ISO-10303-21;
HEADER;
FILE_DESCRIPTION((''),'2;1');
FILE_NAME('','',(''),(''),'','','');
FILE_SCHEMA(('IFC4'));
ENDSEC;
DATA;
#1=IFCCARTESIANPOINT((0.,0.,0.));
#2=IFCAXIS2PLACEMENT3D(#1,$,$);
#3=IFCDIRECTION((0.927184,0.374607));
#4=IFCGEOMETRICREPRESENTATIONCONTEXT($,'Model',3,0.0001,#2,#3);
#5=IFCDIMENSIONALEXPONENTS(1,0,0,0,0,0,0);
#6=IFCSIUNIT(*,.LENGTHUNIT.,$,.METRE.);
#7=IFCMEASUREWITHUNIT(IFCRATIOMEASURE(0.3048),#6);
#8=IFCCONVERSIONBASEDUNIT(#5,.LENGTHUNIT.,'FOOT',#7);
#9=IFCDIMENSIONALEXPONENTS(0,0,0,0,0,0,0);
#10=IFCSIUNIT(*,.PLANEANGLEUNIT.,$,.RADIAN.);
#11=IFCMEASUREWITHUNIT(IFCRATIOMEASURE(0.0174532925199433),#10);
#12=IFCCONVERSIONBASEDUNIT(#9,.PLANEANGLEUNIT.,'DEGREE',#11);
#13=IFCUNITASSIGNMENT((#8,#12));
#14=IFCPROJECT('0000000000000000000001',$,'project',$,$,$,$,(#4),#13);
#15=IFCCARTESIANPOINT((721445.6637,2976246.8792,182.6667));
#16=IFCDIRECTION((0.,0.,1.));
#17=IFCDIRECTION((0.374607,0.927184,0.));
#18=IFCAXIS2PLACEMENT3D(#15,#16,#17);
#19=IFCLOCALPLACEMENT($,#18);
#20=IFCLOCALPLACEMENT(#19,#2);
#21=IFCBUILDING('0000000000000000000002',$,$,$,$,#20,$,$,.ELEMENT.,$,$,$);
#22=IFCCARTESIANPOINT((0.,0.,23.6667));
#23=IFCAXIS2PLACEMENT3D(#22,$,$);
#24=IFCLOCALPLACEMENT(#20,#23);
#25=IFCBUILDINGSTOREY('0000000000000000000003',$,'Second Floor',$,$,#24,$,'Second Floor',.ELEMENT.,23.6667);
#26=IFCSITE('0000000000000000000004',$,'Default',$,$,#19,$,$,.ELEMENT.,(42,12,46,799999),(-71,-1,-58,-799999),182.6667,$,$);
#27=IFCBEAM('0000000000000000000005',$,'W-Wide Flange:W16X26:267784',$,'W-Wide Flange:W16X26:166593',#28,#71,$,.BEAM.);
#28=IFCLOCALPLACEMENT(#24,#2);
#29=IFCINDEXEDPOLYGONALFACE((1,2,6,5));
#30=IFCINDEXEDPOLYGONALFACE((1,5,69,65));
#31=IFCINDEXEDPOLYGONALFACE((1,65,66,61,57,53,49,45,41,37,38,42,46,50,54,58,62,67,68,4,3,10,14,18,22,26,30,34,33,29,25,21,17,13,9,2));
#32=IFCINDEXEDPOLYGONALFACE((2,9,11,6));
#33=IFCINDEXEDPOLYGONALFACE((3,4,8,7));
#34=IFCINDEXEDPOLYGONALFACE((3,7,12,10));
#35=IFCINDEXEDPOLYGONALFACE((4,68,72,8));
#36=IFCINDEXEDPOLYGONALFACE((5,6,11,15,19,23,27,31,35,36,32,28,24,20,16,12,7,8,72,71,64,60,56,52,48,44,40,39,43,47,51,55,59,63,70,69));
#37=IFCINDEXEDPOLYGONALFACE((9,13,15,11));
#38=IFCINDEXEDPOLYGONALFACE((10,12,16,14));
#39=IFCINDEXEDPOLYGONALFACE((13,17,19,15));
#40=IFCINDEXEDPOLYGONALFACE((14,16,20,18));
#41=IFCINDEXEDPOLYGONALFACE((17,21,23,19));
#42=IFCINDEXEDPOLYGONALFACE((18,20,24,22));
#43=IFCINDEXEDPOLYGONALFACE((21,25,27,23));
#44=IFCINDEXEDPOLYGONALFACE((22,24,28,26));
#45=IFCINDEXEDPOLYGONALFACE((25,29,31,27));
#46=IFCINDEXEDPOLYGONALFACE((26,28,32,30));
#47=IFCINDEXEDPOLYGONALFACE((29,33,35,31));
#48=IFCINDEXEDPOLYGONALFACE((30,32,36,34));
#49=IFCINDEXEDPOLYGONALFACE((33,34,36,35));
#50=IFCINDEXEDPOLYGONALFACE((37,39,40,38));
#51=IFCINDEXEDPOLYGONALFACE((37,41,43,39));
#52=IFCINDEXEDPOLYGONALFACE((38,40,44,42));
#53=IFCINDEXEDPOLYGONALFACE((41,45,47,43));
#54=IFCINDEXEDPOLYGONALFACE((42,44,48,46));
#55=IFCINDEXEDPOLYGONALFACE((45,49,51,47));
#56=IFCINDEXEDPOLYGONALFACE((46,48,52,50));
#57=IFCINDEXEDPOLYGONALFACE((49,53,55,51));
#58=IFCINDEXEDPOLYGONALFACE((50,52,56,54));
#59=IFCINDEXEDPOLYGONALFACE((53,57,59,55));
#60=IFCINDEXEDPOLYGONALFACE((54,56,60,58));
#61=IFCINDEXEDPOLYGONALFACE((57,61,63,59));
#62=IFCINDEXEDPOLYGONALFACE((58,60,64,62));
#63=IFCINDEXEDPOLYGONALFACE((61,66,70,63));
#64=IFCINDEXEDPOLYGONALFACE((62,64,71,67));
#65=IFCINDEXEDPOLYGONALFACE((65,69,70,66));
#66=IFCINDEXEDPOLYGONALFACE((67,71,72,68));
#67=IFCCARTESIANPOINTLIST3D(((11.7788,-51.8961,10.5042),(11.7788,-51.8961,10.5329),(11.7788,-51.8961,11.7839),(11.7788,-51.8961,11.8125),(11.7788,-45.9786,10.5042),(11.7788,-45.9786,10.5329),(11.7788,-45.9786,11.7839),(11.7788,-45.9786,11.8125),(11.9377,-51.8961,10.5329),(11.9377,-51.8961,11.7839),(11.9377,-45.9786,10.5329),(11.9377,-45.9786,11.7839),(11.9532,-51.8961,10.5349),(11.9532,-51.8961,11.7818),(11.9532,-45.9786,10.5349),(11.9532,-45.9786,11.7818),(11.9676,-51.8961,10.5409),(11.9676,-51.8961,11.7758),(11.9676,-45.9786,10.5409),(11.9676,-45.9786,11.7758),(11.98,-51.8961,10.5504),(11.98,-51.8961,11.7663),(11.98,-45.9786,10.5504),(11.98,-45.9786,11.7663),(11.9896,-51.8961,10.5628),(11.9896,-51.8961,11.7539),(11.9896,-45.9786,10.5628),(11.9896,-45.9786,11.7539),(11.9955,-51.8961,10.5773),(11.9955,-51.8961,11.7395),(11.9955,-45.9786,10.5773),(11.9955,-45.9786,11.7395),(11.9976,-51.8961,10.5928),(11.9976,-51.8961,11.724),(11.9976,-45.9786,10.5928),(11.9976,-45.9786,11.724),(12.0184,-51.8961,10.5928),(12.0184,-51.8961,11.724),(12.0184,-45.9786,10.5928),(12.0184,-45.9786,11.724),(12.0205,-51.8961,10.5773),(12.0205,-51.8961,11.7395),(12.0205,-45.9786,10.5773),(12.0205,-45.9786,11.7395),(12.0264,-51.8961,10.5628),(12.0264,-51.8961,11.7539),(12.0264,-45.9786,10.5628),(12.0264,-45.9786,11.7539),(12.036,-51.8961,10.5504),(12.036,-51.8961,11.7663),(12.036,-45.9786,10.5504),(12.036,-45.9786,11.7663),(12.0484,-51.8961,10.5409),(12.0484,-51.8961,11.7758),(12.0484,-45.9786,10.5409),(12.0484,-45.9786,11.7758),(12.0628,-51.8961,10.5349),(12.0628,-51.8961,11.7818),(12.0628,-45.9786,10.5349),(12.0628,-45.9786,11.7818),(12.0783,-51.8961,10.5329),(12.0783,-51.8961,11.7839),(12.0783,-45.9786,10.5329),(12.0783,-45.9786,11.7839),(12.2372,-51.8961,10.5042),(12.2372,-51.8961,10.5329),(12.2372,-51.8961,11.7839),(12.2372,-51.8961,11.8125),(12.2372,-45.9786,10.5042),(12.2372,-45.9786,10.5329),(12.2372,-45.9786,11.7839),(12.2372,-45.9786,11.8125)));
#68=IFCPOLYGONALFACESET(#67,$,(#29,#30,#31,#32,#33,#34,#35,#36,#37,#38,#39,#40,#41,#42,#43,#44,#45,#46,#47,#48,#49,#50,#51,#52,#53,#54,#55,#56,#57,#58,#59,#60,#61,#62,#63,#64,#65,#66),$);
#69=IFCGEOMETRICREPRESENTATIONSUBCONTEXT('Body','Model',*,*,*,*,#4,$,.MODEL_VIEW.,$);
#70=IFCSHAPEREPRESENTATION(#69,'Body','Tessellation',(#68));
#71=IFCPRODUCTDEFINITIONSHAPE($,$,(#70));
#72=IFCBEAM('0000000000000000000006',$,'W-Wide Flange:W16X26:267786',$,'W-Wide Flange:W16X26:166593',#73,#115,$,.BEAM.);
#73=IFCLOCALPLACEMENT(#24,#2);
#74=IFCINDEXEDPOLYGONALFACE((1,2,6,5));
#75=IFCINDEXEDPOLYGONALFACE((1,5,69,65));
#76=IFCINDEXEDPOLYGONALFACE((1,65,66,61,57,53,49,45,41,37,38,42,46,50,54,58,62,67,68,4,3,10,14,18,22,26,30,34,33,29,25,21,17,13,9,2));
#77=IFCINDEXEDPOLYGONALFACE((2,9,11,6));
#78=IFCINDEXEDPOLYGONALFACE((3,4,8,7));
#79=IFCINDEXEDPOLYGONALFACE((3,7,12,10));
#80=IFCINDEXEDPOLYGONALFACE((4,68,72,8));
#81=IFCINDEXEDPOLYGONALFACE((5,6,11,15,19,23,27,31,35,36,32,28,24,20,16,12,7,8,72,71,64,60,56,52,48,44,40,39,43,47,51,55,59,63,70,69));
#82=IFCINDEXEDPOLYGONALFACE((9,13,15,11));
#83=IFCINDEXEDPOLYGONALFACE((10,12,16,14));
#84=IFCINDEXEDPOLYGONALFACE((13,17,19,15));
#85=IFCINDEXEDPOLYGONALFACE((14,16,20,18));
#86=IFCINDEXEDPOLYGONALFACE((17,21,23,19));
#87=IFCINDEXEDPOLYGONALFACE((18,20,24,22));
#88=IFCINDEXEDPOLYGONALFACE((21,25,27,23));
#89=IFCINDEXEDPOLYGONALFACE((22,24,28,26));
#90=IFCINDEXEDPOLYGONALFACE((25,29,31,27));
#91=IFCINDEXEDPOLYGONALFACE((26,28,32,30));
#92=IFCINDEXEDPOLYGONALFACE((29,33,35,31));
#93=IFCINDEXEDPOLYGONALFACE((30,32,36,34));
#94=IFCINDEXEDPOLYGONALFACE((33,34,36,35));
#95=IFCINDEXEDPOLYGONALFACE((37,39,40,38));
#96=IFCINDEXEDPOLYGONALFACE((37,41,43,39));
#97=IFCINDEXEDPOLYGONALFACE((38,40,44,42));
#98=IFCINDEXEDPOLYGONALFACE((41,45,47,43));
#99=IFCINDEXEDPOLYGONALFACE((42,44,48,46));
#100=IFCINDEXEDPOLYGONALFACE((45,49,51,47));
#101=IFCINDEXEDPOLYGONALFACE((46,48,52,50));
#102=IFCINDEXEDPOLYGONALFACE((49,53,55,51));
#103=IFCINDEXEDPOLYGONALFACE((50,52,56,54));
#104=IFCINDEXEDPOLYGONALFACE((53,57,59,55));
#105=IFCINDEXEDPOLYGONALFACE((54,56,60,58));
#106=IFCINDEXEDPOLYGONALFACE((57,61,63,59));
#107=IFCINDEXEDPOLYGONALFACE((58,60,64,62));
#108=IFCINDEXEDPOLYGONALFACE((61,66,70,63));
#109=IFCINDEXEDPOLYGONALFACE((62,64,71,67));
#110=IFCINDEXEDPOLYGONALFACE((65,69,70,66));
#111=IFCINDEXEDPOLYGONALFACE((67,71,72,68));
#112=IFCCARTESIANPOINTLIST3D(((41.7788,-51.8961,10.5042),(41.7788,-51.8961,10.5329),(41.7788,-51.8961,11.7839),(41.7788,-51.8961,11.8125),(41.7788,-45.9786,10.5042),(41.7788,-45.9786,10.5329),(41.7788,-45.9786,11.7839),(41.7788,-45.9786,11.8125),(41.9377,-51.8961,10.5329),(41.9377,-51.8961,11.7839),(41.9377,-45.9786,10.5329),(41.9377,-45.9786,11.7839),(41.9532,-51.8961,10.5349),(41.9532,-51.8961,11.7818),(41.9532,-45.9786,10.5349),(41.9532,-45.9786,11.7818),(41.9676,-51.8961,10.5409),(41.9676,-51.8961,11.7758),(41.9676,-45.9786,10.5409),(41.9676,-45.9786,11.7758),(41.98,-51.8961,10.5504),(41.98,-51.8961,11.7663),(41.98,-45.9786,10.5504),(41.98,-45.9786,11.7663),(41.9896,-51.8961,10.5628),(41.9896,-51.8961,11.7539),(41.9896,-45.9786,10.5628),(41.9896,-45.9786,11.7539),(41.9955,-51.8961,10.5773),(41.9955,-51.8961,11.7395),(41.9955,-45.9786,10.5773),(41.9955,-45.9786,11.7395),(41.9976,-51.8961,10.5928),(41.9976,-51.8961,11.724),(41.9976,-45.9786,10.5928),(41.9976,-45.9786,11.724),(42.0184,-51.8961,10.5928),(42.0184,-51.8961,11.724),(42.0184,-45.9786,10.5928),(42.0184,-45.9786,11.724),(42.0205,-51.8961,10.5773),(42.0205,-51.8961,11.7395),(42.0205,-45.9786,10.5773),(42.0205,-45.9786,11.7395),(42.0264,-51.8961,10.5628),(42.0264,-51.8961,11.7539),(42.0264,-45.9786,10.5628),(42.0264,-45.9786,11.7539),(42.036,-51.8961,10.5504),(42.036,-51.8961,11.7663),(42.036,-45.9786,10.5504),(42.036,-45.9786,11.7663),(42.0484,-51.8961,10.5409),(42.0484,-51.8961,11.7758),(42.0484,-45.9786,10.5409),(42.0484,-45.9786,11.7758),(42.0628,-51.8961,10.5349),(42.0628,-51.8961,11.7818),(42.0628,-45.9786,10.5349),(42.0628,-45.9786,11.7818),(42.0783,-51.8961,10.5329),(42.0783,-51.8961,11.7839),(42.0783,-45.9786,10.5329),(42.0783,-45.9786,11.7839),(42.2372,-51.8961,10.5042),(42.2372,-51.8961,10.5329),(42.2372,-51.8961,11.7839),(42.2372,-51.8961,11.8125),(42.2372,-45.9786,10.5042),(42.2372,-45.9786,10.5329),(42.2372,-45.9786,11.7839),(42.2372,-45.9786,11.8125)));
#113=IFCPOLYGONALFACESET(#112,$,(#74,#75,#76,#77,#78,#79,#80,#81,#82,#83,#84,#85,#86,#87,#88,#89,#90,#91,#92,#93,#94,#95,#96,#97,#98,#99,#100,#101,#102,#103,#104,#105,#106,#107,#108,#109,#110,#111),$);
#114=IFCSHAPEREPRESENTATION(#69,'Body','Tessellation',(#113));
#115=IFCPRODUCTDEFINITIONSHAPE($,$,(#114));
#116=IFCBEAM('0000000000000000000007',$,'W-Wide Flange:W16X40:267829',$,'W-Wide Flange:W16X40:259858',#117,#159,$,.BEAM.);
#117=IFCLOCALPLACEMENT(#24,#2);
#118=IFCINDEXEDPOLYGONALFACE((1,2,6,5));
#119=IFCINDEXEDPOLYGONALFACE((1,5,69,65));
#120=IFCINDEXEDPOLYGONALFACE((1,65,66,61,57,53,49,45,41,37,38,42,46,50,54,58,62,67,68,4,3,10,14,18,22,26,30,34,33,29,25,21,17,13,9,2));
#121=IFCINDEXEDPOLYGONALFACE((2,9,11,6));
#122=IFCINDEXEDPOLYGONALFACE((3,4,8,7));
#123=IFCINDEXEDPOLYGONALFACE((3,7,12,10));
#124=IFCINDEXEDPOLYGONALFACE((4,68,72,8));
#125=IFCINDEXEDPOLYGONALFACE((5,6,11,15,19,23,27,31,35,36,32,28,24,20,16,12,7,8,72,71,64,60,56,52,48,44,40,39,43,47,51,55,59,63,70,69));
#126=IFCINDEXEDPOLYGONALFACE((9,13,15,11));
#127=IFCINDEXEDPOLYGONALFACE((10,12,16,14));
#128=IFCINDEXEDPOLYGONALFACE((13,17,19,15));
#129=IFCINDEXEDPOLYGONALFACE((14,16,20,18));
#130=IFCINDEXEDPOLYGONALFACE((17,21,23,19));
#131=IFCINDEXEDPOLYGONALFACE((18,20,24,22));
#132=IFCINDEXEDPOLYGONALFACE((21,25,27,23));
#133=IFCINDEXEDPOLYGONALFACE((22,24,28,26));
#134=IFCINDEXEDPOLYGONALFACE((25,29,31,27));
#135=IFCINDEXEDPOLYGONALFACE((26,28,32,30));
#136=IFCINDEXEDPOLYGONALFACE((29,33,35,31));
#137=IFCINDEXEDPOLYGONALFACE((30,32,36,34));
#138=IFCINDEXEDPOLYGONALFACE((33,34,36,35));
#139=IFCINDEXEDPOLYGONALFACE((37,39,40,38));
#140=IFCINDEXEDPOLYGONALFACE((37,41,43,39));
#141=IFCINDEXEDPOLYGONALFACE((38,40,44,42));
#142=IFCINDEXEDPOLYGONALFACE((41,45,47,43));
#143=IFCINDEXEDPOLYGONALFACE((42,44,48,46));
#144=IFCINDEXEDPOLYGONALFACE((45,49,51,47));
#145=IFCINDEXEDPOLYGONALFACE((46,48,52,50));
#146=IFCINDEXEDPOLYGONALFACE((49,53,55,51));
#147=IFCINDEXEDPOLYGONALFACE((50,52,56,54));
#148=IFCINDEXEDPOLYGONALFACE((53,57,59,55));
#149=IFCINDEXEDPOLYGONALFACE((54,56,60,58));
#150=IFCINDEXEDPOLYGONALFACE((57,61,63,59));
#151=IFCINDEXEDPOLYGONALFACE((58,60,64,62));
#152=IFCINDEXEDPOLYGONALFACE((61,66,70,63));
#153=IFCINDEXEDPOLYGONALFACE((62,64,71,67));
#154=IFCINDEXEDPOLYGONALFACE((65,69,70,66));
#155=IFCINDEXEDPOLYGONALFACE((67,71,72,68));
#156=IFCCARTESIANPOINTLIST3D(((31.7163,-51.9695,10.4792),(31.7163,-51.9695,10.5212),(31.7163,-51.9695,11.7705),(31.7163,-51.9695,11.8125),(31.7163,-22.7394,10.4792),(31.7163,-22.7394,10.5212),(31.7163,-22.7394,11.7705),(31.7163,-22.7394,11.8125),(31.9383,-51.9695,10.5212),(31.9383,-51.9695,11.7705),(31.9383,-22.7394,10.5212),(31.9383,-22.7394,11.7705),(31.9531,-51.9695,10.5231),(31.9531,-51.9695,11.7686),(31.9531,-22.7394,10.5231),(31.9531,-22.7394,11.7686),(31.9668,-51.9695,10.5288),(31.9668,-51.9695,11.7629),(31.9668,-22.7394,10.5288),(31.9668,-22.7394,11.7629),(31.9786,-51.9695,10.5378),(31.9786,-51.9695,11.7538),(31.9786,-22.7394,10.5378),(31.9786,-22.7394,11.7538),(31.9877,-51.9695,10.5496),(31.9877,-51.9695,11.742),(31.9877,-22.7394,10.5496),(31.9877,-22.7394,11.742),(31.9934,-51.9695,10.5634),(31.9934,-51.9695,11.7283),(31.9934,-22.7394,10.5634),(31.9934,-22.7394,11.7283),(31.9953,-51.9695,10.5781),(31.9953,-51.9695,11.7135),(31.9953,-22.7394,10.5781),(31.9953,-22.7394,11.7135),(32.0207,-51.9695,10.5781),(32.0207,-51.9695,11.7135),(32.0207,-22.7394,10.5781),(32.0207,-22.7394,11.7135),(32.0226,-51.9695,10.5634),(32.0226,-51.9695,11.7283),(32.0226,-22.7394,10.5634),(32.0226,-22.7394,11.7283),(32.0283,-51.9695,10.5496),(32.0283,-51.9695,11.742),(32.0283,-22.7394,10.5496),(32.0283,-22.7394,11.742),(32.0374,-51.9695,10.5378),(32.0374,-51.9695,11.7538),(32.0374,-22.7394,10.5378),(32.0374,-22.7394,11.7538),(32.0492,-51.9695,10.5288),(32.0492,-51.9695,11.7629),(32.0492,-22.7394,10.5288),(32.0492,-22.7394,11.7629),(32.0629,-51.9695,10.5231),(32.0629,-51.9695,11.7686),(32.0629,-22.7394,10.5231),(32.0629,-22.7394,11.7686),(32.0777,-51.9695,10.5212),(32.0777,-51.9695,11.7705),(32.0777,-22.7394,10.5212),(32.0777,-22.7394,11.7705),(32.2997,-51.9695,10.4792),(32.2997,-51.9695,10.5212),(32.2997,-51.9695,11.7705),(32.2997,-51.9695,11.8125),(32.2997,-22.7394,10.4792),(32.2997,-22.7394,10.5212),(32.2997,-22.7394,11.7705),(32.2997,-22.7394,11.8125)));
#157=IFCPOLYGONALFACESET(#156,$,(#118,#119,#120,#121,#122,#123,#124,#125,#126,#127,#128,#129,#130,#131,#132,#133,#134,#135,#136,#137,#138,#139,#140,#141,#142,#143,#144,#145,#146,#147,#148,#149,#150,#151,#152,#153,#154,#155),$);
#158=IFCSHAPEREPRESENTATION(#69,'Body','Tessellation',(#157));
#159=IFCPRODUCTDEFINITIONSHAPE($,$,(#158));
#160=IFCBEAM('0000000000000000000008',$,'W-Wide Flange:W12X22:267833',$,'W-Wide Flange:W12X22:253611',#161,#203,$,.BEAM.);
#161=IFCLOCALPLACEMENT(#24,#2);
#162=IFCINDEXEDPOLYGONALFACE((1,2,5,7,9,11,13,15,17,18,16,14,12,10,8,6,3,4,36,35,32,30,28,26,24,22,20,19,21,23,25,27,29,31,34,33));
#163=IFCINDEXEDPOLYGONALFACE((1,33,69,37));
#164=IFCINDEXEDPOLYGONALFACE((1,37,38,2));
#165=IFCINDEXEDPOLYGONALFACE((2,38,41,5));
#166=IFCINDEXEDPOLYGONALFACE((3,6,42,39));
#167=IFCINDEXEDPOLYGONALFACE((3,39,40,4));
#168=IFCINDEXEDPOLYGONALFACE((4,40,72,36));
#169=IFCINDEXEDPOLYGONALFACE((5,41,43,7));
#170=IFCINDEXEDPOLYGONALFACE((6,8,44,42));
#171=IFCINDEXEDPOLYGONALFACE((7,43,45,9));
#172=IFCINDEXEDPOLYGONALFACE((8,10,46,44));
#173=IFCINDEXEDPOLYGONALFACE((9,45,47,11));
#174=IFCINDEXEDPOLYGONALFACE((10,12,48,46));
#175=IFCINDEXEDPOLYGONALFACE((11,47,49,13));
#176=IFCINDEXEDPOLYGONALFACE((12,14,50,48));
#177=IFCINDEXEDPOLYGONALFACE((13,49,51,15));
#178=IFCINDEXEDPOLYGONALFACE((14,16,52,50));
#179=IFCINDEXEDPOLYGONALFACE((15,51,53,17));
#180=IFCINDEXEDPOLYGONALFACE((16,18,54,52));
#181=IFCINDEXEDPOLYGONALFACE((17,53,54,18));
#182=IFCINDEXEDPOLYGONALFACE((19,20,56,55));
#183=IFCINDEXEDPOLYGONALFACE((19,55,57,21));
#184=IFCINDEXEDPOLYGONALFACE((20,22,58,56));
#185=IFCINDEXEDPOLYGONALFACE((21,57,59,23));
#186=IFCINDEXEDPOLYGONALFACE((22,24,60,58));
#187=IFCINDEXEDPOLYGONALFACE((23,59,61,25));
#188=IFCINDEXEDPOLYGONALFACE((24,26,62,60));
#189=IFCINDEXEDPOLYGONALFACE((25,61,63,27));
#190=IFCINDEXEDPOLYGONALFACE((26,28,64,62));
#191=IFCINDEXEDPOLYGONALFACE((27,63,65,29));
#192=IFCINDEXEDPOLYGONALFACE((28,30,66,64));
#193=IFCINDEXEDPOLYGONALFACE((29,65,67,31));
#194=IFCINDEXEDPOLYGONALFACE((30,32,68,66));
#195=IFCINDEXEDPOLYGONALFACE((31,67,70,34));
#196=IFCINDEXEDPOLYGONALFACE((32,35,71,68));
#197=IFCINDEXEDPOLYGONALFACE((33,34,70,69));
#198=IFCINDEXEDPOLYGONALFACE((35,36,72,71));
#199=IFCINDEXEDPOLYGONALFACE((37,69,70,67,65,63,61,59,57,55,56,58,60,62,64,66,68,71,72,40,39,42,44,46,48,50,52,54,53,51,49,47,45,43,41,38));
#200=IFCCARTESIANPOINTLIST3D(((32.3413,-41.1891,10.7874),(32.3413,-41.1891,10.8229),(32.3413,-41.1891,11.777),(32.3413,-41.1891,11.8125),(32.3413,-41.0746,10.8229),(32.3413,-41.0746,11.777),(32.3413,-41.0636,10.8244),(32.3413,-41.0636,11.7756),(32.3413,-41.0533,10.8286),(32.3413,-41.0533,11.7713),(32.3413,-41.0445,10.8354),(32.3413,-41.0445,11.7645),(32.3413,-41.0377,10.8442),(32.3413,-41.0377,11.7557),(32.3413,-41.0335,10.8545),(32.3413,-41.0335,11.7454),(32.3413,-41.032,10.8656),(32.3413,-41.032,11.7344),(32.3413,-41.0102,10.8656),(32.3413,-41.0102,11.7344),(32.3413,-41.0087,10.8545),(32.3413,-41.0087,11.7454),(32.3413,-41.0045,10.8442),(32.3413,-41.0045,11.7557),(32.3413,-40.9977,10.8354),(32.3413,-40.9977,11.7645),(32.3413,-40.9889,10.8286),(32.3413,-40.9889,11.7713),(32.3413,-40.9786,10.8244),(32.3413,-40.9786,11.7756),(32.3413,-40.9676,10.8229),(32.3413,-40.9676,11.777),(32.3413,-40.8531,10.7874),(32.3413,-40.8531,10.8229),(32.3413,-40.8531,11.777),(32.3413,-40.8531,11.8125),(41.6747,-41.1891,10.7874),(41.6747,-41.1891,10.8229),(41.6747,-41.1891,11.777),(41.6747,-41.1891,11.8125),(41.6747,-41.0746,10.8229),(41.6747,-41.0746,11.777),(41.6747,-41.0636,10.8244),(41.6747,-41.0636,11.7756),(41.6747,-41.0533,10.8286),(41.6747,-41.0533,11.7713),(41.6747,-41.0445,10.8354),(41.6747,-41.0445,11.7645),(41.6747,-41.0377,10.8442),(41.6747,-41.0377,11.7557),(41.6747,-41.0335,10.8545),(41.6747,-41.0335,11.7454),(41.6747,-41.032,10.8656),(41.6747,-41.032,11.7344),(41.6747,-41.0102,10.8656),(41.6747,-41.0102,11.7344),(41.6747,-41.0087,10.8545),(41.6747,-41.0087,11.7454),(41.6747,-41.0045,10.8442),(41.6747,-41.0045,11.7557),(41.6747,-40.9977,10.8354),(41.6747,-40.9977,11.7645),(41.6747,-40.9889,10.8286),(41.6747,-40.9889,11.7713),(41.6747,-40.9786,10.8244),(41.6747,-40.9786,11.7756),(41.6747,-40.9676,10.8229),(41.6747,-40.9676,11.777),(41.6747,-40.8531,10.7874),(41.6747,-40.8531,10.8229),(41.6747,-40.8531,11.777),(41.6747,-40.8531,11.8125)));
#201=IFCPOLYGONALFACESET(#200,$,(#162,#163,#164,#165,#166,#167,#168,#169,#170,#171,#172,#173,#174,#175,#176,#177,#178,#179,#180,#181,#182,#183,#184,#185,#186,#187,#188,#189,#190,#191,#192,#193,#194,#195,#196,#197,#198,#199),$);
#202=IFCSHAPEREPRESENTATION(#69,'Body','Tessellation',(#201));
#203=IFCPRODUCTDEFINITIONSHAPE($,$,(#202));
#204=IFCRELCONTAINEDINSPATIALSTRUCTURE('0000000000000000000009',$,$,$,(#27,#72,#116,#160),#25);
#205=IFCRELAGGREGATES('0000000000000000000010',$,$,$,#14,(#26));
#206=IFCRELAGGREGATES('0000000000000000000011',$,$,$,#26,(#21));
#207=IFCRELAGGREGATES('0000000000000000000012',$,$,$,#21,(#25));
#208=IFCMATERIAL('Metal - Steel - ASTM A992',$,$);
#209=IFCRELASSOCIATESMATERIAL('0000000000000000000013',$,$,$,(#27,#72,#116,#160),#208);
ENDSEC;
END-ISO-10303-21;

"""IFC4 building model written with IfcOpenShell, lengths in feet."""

from ifc_helpers import new_model, entity, si_unit, converted_unit, direction, frame, frame_2d, origin, place, context, subcontext, project, spatial, i_section, extrude, material, element, save


model = new_model("IFC4")

# Units and contexts
model_context = context("Model", 3, precision=0.0001, world=origin(), true_north=direction((0.927184, 0.374607)))
body_context = subcontext(model_context, "Body", "Model", "MODEL_VIEW")
ifc_project = project(units=[converted_unit("LENGTHUNIT", "FOOT", entity("IfcRatioMeasure", 0.3048), si_unit("LENGTHUNIT", "METRE"), dimensions=[1, 0, 0, 0, 0, 0, 0]), converted_unit("PLANEANGLEUNIT", "DEGREE", entity("IfcRatioMeasure", 0.0174532925199433), si_unit("PLANEANGLEUNIT", "RADIAN"), dimensions=[0, 0, 0, 0, 0, 0, 0])], contexts=[model_context])

# Site, building, storey
site_placement = place(None, frame((721445.6637, 2976246.8792, 182.6667), z_axis=(0.0, 0.0, 1.0), x_axis=(0.374607, 0.927184, 0.0)))
site = spatial("IfcSite", under=ifc_project, at=site_placement, Name="Default", CompositionType="ELEMENT", RefLatitude=(42, 12, 46, 799999), RefLongitude=(-71, -1, -58, -799999), RefElevation=182.6667)
building_placement = place(site_placement, origin())
building = spatial("IfcBuilding", under=site, at=building_placement, CompositionType="ELEMENT")
storey_placement = place(building_placement, frame((0.0, 0.0, 23.6667)))
storey = spatial("IfcBuildingStorey", under=building, at=storey_placement, Name="Second Floor", LongName="Second Floor", CompositionType="ELEMENT", Elevation=23.6667)

# Shared definitions
ifc_material_1 = material(Name="Metal - Steel - ASTM A992")

# Beams
beam_1_placement = place(storey_placement, frame((12.008, -52.3544, 11.8125), z_axis=(0.0, 0.0, 1.0), x_axis=(0.0, 1.0, 0.0)))
element("IfcBeam", 1, at=beam_1_placement, inside=storey, material=ifc_material_1, Name="W-Wide Flange:W16X26:267784", ObjectType="W-Wide Flange:W16X26:166593", PredefinedType="BEAM", context=body_context, shape_type="SweptSolid", body=[
    extrude(i_section(OverallWidth=0.4583, OverallDepth=1.3083, WebThickness=0.0208, FlangeThickness=0.0286, FilletRadius=0.0599, at=frame_2d((0.0, 0.0), x_axis=(0.0, 1.0))), frame((0.4583, 0.0, -0.6541), z_axis=(1.0, 0.0, 0.0), x_axis=(0.0, 0.0, -1.0)), (0.0, 0.0, 1.0), 5.9175),
])
beam_2_placement = place(storey_placement, frame((42.008, -52.3544, 11.8125), z_axis=(0.0, 0.0, 1.0), x_axis=(0.0, 1.0, 0.0)))
element("IfcBeam", 2, at=beam_2_placement, inside=storey, material=ifc_material_1, Name="W-Wide Flange:W16X26:267786", ObjectType="W-Wide Flange:W16X26:166593", PredefinedType="BEAM", context=body_context, shape_type="SweptSolid", body=[
    extrude(i_section(OverallWidth=0.4583, OverallDepth=1.3083, WebThickness=0.0208, FlangeThickness=0.0286, FilletRadius=0.0599, at=frame_2d((0.0, 0.0), x_axis=(0.0, 1.0))), frame((0.4583, 0.0, -0.6541), z_axis=(1.0, 0.0, 0.0), x_axis=(0.0, 0.0, -1.0)), (0.0, 0.0, 1.0), 5.9175),
])
beam_3_placement = place(storey_placement, frame((32.008, -52.3544, 11.8125), z_axis=(0.0, 0.0, 1.0), x_axis=(0.0, 1.0, 0.0)))
element("IfcBeam", 3, at=beam_3_placement, inside=storey, material=ifc_material_1, Name="W-Wide Flange:W16X40:267829", ObjectType="W-Wide Flange:W16X40:259858", PredefinedType="BEAM", context=body_context, shape_type="SweptSolid", body=[
    extrude(i_section(OverallWidth=0.5833, OverallDepth=1.3333, WebThickness=0.0254, FlangeThickness=0.042, FilletRadius=0.057, at=frame_2d((0.0, 0.0), x_axis=(0.0, 1.0))), frame((0.3849, 0.0, -0.6667), z_axis=(1.0, 0.0, 0.0), x_axis=(0.0, 0.0, -1.0)), (0.0, 0.0, 1.0), 29.2301),
])
beam_4_placement = place(storey_placement, frame((42.008, -41.0211, 11.8125), z_axis=(0.0, 0.0, 1.0), x_axis=(-1.0, 0.0, 0.0)))
element("IfcBeam", 4, at=beam_4_placement, inside=storey, material=ifc_material_1, Name="W-Wide Flange:W12X22:267833", ObjectType="W-Wide Flange:W12X22:253611", PredefinedType="BEAM", context=body_context, shape_type="SweptSolid", body=[
    extrude(i_section(OverallWidth=0.3359, OverallDepth=1.0251, WebThickness=0.0218, FlangeThickness=0.0355, FilletRadius=0.0426, at=frame_2d((0.0, 0.0), x_axis=(0.0, 1.0))), frame((0.3333, 0.0, -0.5125), z_axis=(1.0, 0.0, 0.0), x_axis=(0.0, 0.0, -1.0)), (0.0, 0.0, 1.0), 9.3333),
])

save(model, "model.ifc")
